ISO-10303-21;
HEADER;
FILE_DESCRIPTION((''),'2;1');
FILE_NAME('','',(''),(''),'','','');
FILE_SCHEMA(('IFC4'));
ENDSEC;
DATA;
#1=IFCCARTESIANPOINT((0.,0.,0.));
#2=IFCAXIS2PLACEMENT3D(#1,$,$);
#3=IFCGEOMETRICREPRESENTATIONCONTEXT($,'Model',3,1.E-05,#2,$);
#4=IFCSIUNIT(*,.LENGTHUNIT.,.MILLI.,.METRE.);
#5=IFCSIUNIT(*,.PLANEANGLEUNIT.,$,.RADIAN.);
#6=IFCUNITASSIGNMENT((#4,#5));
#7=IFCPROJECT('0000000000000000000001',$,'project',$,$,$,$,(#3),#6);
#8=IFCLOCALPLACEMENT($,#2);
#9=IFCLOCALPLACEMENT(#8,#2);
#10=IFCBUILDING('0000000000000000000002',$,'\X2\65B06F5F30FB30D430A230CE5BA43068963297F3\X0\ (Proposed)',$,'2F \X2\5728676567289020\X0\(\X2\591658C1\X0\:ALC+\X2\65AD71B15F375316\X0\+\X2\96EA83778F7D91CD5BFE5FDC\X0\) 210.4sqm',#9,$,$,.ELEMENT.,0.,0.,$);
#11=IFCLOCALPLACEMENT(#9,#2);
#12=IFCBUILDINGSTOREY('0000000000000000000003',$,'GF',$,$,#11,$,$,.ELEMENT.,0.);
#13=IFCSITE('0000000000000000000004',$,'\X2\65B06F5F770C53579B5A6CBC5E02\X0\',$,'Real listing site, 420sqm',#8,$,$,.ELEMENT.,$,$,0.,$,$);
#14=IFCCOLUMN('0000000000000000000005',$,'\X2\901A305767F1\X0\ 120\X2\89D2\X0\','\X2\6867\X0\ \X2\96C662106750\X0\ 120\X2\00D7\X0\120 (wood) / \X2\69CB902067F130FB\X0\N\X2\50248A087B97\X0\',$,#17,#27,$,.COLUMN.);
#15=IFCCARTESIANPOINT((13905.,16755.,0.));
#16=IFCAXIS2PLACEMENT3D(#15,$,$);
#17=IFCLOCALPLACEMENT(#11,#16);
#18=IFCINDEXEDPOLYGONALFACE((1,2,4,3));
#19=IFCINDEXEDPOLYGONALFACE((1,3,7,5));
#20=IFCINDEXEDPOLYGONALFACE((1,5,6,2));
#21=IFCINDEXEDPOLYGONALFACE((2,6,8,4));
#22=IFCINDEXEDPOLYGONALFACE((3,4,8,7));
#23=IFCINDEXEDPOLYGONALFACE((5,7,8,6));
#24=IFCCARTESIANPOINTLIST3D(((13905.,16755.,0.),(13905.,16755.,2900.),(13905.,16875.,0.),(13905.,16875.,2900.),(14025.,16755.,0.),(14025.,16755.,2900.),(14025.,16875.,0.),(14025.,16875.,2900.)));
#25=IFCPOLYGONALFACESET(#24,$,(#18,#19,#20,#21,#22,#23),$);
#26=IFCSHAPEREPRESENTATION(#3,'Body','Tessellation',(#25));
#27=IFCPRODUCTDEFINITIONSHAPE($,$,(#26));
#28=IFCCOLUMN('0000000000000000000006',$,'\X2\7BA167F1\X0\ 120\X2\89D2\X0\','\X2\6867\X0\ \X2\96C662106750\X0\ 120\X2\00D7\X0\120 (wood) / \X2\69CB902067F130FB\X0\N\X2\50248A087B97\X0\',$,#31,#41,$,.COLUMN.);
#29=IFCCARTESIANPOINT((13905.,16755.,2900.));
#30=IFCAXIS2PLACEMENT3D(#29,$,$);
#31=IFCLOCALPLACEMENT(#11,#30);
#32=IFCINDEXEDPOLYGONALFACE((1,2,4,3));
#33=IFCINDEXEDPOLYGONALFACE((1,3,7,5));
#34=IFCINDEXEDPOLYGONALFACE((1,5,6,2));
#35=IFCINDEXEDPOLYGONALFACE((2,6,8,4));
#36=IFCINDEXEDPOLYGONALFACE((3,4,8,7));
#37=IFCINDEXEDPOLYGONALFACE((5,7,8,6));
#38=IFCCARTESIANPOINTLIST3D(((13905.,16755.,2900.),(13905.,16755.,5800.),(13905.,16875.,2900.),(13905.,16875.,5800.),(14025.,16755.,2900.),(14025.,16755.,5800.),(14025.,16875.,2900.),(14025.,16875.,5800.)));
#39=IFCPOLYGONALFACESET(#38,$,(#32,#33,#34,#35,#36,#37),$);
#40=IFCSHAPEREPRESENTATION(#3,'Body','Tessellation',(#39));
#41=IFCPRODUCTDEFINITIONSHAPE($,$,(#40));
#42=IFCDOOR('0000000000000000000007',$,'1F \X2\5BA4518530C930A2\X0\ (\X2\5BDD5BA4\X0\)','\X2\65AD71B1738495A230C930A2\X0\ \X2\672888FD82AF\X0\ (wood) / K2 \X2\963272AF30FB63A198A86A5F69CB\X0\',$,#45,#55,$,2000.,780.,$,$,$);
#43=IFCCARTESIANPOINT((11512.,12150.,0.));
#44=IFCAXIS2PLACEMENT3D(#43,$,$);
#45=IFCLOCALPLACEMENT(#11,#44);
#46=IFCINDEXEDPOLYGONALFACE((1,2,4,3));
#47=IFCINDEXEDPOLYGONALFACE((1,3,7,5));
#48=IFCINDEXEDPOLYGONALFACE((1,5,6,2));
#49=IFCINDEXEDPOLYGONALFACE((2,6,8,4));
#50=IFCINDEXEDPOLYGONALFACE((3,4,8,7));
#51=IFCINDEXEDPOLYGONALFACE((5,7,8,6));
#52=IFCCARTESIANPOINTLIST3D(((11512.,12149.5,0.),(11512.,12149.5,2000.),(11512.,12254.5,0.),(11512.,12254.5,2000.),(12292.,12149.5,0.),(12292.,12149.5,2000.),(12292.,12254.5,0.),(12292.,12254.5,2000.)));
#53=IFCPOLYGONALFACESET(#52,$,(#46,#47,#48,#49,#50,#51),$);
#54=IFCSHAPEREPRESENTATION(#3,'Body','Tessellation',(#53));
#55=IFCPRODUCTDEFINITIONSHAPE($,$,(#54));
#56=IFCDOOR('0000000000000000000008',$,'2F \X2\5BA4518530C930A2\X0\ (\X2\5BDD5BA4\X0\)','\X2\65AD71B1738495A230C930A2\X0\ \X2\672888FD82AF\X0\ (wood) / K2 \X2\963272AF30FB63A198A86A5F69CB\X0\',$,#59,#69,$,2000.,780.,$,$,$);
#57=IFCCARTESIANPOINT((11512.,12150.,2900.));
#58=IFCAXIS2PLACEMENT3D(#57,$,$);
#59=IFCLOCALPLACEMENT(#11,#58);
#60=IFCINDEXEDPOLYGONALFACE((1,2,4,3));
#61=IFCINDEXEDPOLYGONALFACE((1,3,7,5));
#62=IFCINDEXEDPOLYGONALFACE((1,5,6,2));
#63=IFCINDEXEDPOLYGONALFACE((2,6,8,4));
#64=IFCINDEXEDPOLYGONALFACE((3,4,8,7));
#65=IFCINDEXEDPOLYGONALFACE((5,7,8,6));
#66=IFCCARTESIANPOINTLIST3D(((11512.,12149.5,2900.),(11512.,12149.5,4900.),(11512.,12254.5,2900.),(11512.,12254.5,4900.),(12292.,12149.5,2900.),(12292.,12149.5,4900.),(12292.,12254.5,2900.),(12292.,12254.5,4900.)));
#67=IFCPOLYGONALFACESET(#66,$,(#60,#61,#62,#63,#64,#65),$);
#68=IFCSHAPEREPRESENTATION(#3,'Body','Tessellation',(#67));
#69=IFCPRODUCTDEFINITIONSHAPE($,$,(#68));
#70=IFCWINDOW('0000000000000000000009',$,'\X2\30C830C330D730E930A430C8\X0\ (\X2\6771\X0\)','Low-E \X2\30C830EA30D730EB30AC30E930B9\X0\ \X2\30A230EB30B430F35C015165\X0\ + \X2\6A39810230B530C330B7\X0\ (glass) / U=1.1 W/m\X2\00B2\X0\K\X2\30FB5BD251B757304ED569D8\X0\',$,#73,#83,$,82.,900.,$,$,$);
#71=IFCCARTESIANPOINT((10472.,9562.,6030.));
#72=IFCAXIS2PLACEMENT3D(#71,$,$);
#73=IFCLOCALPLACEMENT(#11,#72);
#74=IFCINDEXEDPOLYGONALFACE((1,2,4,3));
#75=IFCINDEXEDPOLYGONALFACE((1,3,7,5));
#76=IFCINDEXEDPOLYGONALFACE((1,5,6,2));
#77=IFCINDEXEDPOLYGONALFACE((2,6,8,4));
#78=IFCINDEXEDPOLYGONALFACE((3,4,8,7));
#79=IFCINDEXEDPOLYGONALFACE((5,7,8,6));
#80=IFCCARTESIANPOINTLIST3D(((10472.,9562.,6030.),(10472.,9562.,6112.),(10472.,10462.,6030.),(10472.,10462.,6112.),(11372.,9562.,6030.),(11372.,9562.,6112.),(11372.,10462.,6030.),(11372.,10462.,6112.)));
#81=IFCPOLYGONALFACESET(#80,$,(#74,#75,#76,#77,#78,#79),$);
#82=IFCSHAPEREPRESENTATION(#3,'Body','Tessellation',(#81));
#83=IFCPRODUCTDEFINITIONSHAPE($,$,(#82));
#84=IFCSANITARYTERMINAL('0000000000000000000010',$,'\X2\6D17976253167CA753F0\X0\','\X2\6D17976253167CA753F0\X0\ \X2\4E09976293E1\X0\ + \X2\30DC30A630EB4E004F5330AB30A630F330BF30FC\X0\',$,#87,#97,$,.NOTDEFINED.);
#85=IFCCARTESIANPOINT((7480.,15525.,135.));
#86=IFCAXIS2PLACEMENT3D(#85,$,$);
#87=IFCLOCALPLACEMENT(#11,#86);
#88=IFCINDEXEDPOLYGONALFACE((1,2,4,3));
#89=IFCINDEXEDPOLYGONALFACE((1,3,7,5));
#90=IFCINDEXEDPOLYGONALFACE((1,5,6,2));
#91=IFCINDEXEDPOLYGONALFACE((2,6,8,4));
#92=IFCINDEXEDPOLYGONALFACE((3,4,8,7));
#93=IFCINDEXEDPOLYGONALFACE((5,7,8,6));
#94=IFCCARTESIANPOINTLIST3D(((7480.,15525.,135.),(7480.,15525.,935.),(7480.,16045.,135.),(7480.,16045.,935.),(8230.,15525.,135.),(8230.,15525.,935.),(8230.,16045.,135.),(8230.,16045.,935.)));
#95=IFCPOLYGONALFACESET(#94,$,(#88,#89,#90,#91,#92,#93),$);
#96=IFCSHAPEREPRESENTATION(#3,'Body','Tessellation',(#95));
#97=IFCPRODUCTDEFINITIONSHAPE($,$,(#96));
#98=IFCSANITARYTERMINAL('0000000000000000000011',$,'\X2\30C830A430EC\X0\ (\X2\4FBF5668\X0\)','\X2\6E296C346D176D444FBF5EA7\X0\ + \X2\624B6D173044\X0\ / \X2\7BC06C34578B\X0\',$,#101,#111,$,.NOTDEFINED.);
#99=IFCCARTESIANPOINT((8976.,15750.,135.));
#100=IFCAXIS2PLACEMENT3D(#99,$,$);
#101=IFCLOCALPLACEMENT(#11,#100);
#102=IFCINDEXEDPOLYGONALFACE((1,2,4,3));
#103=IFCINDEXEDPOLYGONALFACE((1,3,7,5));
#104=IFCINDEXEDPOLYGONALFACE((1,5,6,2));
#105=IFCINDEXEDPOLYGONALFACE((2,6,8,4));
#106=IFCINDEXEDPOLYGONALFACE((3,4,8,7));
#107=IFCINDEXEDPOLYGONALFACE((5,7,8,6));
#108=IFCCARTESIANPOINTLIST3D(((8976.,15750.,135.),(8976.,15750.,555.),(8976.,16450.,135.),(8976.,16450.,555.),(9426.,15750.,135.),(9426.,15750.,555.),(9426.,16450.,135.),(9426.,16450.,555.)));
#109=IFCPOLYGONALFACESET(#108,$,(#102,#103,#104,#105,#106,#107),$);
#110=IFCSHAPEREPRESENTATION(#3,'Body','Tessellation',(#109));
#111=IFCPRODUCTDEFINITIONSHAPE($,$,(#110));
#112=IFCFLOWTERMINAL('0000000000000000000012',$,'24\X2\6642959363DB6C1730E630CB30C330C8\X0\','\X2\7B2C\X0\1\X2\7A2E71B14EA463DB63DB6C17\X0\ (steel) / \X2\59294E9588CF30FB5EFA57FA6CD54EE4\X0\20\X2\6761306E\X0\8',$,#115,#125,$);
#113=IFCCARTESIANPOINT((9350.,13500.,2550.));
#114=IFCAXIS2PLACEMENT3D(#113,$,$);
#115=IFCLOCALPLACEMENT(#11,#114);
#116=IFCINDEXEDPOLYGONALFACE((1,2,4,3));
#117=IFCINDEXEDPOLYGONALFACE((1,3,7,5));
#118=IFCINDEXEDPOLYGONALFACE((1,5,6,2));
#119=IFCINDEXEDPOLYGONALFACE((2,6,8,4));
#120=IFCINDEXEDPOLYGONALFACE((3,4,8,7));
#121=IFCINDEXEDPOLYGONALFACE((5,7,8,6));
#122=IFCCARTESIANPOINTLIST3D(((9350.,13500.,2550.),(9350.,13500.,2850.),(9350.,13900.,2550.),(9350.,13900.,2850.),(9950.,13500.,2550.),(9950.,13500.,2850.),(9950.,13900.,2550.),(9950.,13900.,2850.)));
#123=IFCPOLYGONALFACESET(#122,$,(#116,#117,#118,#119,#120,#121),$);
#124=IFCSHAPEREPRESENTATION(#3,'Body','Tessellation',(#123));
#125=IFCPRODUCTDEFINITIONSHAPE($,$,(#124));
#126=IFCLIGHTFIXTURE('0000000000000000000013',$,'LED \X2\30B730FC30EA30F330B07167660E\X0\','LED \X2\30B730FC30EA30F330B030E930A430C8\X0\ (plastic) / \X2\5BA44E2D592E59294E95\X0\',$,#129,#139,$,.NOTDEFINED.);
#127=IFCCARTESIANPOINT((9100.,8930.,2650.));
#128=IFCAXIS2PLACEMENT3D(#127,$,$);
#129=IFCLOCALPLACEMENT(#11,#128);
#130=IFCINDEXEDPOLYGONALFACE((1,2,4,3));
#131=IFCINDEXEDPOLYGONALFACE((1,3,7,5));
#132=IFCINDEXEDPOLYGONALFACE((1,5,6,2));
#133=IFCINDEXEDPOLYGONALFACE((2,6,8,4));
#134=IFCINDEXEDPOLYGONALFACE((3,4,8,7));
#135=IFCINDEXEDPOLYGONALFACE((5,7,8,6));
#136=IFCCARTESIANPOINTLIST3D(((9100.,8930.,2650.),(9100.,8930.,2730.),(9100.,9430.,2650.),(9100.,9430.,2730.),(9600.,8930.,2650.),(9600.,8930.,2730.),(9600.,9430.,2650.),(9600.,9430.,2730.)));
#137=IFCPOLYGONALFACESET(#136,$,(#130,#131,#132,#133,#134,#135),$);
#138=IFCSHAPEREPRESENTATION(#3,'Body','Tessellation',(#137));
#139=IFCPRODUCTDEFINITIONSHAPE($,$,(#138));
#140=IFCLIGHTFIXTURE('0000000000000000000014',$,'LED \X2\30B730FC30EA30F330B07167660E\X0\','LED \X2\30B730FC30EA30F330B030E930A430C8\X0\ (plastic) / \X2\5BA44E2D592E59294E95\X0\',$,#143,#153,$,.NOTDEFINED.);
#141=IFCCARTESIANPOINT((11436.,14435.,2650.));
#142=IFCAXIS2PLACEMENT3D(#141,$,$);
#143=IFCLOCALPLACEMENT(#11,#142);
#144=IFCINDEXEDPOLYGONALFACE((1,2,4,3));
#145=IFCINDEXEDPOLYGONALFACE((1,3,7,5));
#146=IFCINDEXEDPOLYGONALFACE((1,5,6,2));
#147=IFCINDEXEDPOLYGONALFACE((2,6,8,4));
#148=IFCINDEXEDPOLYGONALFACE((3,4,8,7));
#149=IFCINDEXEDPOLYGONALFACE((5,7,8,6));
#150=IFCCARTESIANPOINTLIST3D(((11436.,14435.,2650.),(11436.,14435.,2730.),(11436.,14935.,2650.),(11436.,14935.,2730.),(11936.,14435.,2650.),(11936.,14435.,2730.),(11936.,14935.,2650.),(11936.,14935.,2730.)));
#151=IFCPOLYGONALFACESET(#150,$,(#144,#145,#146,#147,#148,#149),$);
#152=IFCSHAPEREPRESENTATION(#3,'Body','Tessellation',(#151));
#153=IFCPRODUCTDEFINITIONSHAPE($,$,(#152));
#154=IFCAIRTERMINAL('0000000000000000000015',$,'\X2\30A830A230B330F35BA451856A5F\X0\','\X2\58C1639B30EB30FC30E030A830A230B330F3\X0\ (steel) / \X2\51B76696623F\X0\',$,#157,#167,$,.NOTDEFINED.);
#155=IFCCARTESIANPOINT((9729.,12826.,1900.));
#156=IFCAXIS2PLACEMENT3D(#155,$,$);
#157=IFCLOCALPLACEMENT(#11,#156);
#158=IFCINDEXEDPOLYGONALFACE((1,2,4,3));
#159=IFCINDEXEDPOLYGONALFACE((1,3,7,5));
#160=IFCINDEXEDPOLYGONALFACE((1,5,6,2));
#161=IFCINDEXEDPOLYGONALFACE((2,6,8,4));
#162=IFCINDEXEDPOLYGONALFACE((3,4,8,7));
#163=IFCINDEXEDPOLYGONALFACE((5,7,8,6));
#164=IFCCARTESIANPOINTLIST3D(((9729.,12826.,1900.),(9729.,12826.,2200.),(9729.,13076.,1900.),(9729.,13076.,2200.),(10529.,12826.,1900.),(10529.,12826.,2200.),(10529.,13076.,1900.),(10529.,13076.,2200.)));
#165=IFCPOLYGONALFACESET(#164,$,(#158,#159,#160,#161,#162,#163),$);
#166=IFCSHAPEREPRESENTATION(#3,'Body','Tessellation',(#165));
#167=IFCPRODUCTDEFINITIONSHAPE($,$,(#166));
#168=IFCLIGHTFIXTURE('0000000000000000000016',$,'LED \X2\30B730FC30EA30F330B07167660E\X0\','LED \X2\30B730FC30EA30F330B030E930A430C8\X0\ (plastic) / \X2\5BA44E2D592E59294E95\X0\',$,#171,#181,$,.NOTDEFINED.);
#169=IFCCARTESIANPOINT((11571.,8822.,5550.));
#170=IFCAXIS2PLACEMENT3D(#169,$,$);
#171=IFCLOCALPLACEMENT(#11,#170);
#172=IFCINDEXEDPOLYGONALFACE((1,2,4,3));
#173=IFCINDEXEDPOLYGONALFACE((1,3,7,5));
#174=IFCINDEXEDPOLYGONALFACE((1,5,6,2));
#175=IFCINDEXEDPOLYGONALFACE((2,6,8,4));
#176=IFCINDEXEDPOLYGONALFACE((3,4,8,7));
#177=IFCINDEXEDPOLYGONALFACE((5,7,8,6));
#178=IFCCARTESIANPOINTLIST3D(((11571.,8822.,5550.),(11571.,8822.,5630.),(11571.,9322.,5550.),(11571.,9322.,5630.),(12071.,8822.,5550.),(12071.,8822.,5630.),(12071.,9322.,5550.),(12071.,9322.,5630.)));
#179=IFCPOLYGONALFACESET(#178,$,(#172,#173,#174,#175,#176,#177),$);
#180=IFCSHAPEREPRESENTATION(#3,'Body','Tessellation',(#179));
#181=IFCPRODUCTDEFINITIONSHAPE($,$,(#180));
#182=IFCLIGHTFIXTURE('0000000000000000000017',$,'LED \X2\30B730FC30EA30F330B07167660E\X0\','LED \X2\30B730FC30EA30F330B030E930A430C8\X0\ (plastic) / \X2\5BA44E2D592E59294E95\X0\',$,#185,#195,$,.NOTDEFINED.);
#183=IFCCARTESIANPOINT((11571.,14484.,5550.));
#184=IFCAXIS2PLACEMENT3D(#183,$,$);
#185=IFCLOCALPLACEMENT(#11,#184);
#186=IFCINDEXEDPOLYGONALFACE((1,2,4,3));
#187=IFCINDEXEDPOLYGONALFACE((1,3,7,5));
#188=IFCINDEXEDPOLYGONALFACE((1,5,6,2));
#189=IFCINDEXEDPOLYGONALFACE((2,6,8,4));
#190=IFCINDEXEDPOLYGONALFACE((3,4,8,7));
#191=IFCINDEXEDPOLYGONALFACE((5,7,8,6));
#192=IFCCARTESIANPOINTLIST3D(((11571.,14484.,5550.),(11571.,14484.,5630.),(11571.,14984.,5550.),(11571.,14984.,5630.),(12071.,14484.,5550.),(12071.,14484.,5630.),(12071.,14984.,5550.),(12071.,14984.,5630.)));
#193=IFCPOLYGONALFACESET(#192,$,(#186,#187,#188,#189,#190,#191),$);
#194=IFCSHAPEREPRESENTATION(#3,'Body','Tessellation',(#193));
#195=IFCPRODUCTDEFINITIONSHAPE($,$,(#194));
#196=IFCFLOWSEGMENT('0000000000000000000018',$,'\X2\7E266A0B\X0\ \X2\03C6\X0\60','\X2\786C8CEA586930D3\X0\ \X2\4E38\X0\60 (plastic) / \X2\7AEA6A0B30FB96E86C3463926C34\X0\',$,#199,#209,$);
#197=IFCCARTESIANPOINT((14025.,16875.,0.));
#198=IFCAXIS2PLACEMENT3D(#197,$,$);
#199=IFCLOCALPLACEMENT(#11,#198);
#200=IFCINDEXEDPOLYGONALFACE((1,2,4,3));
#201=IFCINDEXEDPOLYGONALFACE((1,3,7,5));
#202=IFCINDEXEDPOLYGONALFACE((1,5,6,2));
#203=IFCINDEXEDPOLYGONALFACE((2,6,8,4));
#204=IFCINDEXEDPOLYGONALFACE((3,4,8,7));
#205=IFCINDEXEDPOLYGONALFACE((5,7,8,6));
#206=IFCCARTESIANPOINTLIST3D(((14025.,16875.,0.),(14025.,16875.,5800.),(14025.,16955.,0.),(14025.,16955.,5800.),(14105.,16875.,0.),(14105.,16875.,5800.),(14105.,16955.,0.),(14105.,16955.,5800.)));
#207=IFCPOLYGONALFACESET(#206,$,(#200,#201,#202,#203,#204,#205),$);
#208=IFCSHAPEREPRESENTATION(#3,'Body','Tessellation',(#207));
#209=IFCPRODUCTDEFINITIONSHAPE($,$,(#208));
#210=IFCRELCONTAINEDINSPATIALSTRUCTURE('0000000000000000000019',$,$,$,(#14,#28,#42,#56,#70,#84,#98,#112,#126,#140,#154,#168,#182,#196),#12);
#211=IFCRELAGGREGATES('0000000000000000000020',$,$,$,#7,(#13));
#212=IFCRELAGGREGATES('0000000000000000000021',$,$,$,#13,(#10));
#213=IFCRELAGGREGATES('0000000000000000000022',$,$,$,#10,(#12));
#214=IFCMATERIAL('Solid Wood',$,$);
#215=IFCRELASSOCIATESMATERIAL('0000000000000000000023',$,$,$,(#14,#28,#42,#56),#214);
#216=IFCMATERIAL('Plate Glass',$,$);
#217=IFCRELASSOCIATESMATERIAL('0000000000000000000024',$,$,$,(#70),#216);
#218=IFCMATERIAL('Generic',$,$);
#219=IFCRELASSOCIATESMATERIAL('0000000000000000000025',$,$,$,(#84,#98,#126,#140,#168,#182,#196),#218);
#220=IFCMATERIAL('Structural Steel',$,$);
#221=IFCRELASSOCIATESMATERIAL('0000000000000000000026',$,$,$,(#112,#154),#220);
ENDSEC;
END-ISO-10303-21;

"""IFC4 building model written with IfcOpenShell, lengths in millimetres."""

from ifc_helpers import new_model, si_unit, frame, frame_2d, origin, place, context, project, spatial, rectangle, extrude, material, element, save


model = new_model("IFC4")

# Units and contexts
model_context = context("Model", 3, precision=1e-05, world=origin())
ifc_project = project(units=[si_unit("LENGTHUNIT", "METRE", prefix="MILLI"), si_unit("PLANEANGLEUNIT", "RADIAN")], contexts=[model_context])

# Site, building, storey
site_placement = place(None, origin())
site = spatial("IfcSite", under=ifc_project, at=site_placement, Name="新潟県南魚沼市", ObjectType="Real listing site, 420sqm", CompositionType="ELEMENT", RefElevation=0.0)
building_placement = place(site_placement, origin())
building = spatial("IfcBuilding", under=site, at=building_placement, Name="新潟・ピアノ室と防音 (Proposed)", ObjectType="2F 在来木造(外壁:ALC+断熱強化+雪荷载重対応) 210.4sqm", CompositionType="ELEMENT", ElevationOfRefHeight=0.0, ElevationOfTerrain=0.0)
storey_placement = place(building_placement, origin())
storey = spatial("IfcBuildingStorey", under=building, at=storey_placement, Name="GF", CompositionType="ELEMENT", Elevation=0.0)

# Columns
ifc_material_1 = material(Name="Solid Wood")
column_1_placement = place(storey_placement, frame((13905.0, 16755.0, 0.0)))
element("IfcColumn", 1, at=column_1_placement, inside=storey, material=ifc_material_1, Name="通し柱 120角", Description="桧 集成材 120×120 (wood) / 構造柱・N値計算", PredefinedType="COLUMN", context=model_context, shape_type="SweptSolid", body=[
    extrude(rectangle(XDim=120.0, YDim=120.0, at=frame_2d((60.0, 60.0))), frame((13905.0, 16755.0, 0.0)), (0.0, 0.0, 1.0), 2900.0),
])
column_2_placement = place(storey_placement, frame((13905.0, 16755.0, 2900.0)))
element("IfcColumn", 2, at=column_2_placement, inside=storey, material=ifc_material_1, Name="管柱 120角", Description="桧 集成材 120×120 (wood) / 構造柱・N値計算", PredefinedType="COLUMN", context=model_context, shape_type="SweptSolid", body=[
    extrude(rectangle(XDim=120.0, YDim=120.0, at=frame_2d((60.0, 60.0))), frame((13905.0, 16755.0, 2900.0)), (0.0, 0.0, 1.0), 2900.0),
])

# Door
door_1_placement = place(storey_placement, frame((11512.0, 12150.0, 0.0)))
element("IfcDoor", 3, at=door_1_placement, inside=storey, material=ifc_material_1, Name="1F 室内ドア (寝室)", Description="断熱玄関ドア 木製芯 (wood) / K2 防犯・採風機構", OverallHeight=2000.0, OverallWidth=780.0, context=model_context, shape_type="SweptSolid", body=[
    extrude(rectangle(XDim=780.0, YDim=105.0, at=frame_2d((390.0, 52.0))), frame((11512.0, 12150.0, 0.0)), (0.0, 0.0, 1.0), 2000.0),
])

# Door
door_2_placement = place(storey_placement, frame((11512.0, 12150.0, 2900.0)))
element("IfcDoor", 4, at=door_2_placement, inside=storey, material=ifc_material_1, Name="2F 室内ドア (寝室)", Description="断熱玄関ドア 木製芯 (wood) / K2 防犯・採風機構", OverallHeight=2000.0, OverallWidth=780.0, context=model_context, shape_type="SweptSolid", body=[
    extrude(rectangle(XDim=780.0, YDim=105.0, at=frame_2d((390.0, 52.0))), frame((11512.0, 12150.0, 2900.0)), (0.0, 0.0, 1.0), 2000.0),
])

# Window
ifc_material_2 = material(Name="Plate Glass")
window_placement = place(storey_placement, frame((10472.0, 9562.0, 6030.0)))
element("IfcWindow", 5, at=window_placement, inside=storey, material=ifc_material_2, Name="トップライト (東)", Description="Low-E トリプルガラス アルゴン封入 + 樹脂サッシ (glass) / U=1.1 W/m²K・寒冷地仕様", OverallHeight=82.0, OverallWidth=900.0, context=model_context, shape_type="SweptSolid", body=[
    extrude(rectangle(XDim=900.0, YDim=900.0, at=frame_2d((450.0, 450.0))), frame((10472.0, 9562.0, 6030.0)), (0.0, 0.0, 1.0), 82.0),
])

# Sanitary terminals
ifc_material_3 = material(Name="Generic")
sanitary_terminal_1_placement = place(storey_placement, frame((7480.0, 15525.0, 135.0)))
element("IfcSanitaryTerminal", 6, at=sanitary_terminal_1_placement, inside=storey, material=ifc_material_3, Name="洗面化粧台", Description="洗面化粧台 三面鏡 + ボウル一体カウンター", PredefinedType="NOTDEFINED", context=model_context, shape_type="SweptSolid", body=[
    extrude(rectangle(XDim=750.0, YDim=520.0, at=frame_2d((375.0, 260.0))), frame((7480.0, 15525.0, 135.0)), (0.0, 0.0, 1.0), 800.0),
])
sanitary_terminal_2_placement = place(storey_placement, frame((8976.0, 15750.0, 135.0)))
element("IfcSanitaryTerminal", 7, at=sanitary_terminal_2_placement, inside=storey, material=ifc_material_3, Name="トイレ (便器)", Description="温水洗浄便座 + 手洗い / 節水型", PredefinedType="NOTDEFINED", context=model_context, shape_type="SweptSolid", body=[
    extrude(rectangle(XDim=450.0, YDim=700.0, at=frame_2d((225.0, 350.0))), frame((8976.0, 15750.0, 135.0)), (0.0, 0.0, 1.0), 420.0),
])

# Flow terminal
ifc_material_4 = material(Name="Structural Steel")
flow_terminal_placement = place(storey_placement, frame((9350.0, 13500.0, 2550.0)))
element("IfcFlowTerminal", 8, at=flow_terminal_placement, inside=storey, material=ifc_material_4, Name="24時間換気ユニット", Description="第1種熱交換換気 (steel) / 天井裏・建基法令20条の8", context=model_context, shape_type="SweptSolid", body=[
    extrude(rectangle(XDim=600.0, YDim=400.0, at=frame_2d((300.0, 200.0))), frame((9350.0, 13500.0, 2550.0)), (0.0, 0.0, 1.0), 300.0),
])

# Light fixtures
light_fixture_1_placement = place(storey_placement, frame((9100.0, 8930.0, 2650.0)))
element("IfcLightFixture", 9, at=light_fixture_1_placement, inside=storey, material=ifc_material_3, Name="LED シーリング照明", Description="LED シーリングライト (plastic) / 室中央天井", PredefinedType="NOTDEFINED", context=model_context, shape_type="SweptSolid", body=[
    extrude(rectangle(XDim=500.0, YDim=500.0, at=frame_2d((250.0, 250.0))), frame((9100.0, 8930.0, 2650.0)), (0.0, 0.0, 1.0), 80.0),
])
light_fixture_2_placement = place(storey_placement, frame((11436.0, 14435.0, 2650.0)))
element("IfcLightFixture", 10, at=light_fixture_2_placement, inside=storey, material=ifc_material_3, Name="LED シーリング照明", Description="LED シーリングライト (plastic) / 室中央天井", PredefinedType="NOTDEFINED", context=model_context, shape_type="SweptSolid", body=[
    extrude(rectangle(XDim=500.0, YDim=500.0, at=frame_2d((250.0, 250.0))), frame((11436.0, 14435.0, 2650.0)), (0.0, 0.0, 1.0), 80.0),
])

# Air terminal
air_terminal_placement = place(storey_placement, frame((9729.0, 12826.0, 1900.0)))
element("IfcAirTerminal", 11, at=air_terminal_placement, inside=storey, material=ifc_material_4, Name="エアコン室内機", Description="壁掛ルームエアコン (steel) / 冷暖房", PredefinedType="NOTDEFINED", context=model_context, shape_type="SweptSolid", body=[
    extrude(rectangle(XDim=800.0, YDim=250.0, at=frame_2d((400.0, 125.0))), frame((9729.0, 12826.0, 1900.0)), (0.0, 0.0, 1.0), 300.0),
])

# Light fixtures
light_fixture_3_placement = place(storey_placement, frame((11571.0, 8822.0, 5550.0)))
element("IfcLightFixture", 12, at=light_fixture_3_placement, inside=storey, material=ifc_material_3, Name="LED シーリング照明", Description="LED シーリングライト (plastic) / 室中央天井", PredefinedType="NOTDEFINED", context=model_context, shape_type="SweptSolid", body=[
    extrude(rectangle(XDim=500.0, YDim=500.0, at=frame_2d((250.0, 250.0))), frame((11571.0, 8822.0, 5550.0)), (0.0, 0.0, 1.0), 80.0),
])
light_fixture_4_placement = place(storey_placement, frame((11571.0, 14484.0, 5550.0)))
element("IfcLightFixture", 13, at=light_fixture_4_placement, inside=storey, material=ifc_material_3, Name="LED シーリング照明", Description="LED シーリングライト (plastic) / 室中央天井", PredefinedType="NOTDEFINED", context=model_context, shape_type="SweptSolid", body=[
    extrude(rectangle(XDim=500.0, YDim=500.0, at=frame_2d((250.0, 250.0))), frame((11571.0, 14484.0, 5550.0)), (0.0, 0.0, 1.0), 80.0),
])

# Flow segment
flow_segment_placement = place(storey_placement, frame((14025.0, 16875.0, 0.0)))
element("IfcFlowSegment", 14, at=flow_segment_placement, inside=storey, material=ifc_material_3, Name="縦樋 φ60", Description="硬質塩ビ 丸60 (plastic) / 竪樋・雨水排水", context=model_context, shape_type="SweptSolid", body=[
    extrude(rectangle(XDim=80.0, YDim=80.0, at=frame_2d((40.0, 40.0))), frame((14025.0, 16875.0, 0.0)), (0.0, 0.0, 1.0), 5800.0),
])

save(model, "model.ifc")
